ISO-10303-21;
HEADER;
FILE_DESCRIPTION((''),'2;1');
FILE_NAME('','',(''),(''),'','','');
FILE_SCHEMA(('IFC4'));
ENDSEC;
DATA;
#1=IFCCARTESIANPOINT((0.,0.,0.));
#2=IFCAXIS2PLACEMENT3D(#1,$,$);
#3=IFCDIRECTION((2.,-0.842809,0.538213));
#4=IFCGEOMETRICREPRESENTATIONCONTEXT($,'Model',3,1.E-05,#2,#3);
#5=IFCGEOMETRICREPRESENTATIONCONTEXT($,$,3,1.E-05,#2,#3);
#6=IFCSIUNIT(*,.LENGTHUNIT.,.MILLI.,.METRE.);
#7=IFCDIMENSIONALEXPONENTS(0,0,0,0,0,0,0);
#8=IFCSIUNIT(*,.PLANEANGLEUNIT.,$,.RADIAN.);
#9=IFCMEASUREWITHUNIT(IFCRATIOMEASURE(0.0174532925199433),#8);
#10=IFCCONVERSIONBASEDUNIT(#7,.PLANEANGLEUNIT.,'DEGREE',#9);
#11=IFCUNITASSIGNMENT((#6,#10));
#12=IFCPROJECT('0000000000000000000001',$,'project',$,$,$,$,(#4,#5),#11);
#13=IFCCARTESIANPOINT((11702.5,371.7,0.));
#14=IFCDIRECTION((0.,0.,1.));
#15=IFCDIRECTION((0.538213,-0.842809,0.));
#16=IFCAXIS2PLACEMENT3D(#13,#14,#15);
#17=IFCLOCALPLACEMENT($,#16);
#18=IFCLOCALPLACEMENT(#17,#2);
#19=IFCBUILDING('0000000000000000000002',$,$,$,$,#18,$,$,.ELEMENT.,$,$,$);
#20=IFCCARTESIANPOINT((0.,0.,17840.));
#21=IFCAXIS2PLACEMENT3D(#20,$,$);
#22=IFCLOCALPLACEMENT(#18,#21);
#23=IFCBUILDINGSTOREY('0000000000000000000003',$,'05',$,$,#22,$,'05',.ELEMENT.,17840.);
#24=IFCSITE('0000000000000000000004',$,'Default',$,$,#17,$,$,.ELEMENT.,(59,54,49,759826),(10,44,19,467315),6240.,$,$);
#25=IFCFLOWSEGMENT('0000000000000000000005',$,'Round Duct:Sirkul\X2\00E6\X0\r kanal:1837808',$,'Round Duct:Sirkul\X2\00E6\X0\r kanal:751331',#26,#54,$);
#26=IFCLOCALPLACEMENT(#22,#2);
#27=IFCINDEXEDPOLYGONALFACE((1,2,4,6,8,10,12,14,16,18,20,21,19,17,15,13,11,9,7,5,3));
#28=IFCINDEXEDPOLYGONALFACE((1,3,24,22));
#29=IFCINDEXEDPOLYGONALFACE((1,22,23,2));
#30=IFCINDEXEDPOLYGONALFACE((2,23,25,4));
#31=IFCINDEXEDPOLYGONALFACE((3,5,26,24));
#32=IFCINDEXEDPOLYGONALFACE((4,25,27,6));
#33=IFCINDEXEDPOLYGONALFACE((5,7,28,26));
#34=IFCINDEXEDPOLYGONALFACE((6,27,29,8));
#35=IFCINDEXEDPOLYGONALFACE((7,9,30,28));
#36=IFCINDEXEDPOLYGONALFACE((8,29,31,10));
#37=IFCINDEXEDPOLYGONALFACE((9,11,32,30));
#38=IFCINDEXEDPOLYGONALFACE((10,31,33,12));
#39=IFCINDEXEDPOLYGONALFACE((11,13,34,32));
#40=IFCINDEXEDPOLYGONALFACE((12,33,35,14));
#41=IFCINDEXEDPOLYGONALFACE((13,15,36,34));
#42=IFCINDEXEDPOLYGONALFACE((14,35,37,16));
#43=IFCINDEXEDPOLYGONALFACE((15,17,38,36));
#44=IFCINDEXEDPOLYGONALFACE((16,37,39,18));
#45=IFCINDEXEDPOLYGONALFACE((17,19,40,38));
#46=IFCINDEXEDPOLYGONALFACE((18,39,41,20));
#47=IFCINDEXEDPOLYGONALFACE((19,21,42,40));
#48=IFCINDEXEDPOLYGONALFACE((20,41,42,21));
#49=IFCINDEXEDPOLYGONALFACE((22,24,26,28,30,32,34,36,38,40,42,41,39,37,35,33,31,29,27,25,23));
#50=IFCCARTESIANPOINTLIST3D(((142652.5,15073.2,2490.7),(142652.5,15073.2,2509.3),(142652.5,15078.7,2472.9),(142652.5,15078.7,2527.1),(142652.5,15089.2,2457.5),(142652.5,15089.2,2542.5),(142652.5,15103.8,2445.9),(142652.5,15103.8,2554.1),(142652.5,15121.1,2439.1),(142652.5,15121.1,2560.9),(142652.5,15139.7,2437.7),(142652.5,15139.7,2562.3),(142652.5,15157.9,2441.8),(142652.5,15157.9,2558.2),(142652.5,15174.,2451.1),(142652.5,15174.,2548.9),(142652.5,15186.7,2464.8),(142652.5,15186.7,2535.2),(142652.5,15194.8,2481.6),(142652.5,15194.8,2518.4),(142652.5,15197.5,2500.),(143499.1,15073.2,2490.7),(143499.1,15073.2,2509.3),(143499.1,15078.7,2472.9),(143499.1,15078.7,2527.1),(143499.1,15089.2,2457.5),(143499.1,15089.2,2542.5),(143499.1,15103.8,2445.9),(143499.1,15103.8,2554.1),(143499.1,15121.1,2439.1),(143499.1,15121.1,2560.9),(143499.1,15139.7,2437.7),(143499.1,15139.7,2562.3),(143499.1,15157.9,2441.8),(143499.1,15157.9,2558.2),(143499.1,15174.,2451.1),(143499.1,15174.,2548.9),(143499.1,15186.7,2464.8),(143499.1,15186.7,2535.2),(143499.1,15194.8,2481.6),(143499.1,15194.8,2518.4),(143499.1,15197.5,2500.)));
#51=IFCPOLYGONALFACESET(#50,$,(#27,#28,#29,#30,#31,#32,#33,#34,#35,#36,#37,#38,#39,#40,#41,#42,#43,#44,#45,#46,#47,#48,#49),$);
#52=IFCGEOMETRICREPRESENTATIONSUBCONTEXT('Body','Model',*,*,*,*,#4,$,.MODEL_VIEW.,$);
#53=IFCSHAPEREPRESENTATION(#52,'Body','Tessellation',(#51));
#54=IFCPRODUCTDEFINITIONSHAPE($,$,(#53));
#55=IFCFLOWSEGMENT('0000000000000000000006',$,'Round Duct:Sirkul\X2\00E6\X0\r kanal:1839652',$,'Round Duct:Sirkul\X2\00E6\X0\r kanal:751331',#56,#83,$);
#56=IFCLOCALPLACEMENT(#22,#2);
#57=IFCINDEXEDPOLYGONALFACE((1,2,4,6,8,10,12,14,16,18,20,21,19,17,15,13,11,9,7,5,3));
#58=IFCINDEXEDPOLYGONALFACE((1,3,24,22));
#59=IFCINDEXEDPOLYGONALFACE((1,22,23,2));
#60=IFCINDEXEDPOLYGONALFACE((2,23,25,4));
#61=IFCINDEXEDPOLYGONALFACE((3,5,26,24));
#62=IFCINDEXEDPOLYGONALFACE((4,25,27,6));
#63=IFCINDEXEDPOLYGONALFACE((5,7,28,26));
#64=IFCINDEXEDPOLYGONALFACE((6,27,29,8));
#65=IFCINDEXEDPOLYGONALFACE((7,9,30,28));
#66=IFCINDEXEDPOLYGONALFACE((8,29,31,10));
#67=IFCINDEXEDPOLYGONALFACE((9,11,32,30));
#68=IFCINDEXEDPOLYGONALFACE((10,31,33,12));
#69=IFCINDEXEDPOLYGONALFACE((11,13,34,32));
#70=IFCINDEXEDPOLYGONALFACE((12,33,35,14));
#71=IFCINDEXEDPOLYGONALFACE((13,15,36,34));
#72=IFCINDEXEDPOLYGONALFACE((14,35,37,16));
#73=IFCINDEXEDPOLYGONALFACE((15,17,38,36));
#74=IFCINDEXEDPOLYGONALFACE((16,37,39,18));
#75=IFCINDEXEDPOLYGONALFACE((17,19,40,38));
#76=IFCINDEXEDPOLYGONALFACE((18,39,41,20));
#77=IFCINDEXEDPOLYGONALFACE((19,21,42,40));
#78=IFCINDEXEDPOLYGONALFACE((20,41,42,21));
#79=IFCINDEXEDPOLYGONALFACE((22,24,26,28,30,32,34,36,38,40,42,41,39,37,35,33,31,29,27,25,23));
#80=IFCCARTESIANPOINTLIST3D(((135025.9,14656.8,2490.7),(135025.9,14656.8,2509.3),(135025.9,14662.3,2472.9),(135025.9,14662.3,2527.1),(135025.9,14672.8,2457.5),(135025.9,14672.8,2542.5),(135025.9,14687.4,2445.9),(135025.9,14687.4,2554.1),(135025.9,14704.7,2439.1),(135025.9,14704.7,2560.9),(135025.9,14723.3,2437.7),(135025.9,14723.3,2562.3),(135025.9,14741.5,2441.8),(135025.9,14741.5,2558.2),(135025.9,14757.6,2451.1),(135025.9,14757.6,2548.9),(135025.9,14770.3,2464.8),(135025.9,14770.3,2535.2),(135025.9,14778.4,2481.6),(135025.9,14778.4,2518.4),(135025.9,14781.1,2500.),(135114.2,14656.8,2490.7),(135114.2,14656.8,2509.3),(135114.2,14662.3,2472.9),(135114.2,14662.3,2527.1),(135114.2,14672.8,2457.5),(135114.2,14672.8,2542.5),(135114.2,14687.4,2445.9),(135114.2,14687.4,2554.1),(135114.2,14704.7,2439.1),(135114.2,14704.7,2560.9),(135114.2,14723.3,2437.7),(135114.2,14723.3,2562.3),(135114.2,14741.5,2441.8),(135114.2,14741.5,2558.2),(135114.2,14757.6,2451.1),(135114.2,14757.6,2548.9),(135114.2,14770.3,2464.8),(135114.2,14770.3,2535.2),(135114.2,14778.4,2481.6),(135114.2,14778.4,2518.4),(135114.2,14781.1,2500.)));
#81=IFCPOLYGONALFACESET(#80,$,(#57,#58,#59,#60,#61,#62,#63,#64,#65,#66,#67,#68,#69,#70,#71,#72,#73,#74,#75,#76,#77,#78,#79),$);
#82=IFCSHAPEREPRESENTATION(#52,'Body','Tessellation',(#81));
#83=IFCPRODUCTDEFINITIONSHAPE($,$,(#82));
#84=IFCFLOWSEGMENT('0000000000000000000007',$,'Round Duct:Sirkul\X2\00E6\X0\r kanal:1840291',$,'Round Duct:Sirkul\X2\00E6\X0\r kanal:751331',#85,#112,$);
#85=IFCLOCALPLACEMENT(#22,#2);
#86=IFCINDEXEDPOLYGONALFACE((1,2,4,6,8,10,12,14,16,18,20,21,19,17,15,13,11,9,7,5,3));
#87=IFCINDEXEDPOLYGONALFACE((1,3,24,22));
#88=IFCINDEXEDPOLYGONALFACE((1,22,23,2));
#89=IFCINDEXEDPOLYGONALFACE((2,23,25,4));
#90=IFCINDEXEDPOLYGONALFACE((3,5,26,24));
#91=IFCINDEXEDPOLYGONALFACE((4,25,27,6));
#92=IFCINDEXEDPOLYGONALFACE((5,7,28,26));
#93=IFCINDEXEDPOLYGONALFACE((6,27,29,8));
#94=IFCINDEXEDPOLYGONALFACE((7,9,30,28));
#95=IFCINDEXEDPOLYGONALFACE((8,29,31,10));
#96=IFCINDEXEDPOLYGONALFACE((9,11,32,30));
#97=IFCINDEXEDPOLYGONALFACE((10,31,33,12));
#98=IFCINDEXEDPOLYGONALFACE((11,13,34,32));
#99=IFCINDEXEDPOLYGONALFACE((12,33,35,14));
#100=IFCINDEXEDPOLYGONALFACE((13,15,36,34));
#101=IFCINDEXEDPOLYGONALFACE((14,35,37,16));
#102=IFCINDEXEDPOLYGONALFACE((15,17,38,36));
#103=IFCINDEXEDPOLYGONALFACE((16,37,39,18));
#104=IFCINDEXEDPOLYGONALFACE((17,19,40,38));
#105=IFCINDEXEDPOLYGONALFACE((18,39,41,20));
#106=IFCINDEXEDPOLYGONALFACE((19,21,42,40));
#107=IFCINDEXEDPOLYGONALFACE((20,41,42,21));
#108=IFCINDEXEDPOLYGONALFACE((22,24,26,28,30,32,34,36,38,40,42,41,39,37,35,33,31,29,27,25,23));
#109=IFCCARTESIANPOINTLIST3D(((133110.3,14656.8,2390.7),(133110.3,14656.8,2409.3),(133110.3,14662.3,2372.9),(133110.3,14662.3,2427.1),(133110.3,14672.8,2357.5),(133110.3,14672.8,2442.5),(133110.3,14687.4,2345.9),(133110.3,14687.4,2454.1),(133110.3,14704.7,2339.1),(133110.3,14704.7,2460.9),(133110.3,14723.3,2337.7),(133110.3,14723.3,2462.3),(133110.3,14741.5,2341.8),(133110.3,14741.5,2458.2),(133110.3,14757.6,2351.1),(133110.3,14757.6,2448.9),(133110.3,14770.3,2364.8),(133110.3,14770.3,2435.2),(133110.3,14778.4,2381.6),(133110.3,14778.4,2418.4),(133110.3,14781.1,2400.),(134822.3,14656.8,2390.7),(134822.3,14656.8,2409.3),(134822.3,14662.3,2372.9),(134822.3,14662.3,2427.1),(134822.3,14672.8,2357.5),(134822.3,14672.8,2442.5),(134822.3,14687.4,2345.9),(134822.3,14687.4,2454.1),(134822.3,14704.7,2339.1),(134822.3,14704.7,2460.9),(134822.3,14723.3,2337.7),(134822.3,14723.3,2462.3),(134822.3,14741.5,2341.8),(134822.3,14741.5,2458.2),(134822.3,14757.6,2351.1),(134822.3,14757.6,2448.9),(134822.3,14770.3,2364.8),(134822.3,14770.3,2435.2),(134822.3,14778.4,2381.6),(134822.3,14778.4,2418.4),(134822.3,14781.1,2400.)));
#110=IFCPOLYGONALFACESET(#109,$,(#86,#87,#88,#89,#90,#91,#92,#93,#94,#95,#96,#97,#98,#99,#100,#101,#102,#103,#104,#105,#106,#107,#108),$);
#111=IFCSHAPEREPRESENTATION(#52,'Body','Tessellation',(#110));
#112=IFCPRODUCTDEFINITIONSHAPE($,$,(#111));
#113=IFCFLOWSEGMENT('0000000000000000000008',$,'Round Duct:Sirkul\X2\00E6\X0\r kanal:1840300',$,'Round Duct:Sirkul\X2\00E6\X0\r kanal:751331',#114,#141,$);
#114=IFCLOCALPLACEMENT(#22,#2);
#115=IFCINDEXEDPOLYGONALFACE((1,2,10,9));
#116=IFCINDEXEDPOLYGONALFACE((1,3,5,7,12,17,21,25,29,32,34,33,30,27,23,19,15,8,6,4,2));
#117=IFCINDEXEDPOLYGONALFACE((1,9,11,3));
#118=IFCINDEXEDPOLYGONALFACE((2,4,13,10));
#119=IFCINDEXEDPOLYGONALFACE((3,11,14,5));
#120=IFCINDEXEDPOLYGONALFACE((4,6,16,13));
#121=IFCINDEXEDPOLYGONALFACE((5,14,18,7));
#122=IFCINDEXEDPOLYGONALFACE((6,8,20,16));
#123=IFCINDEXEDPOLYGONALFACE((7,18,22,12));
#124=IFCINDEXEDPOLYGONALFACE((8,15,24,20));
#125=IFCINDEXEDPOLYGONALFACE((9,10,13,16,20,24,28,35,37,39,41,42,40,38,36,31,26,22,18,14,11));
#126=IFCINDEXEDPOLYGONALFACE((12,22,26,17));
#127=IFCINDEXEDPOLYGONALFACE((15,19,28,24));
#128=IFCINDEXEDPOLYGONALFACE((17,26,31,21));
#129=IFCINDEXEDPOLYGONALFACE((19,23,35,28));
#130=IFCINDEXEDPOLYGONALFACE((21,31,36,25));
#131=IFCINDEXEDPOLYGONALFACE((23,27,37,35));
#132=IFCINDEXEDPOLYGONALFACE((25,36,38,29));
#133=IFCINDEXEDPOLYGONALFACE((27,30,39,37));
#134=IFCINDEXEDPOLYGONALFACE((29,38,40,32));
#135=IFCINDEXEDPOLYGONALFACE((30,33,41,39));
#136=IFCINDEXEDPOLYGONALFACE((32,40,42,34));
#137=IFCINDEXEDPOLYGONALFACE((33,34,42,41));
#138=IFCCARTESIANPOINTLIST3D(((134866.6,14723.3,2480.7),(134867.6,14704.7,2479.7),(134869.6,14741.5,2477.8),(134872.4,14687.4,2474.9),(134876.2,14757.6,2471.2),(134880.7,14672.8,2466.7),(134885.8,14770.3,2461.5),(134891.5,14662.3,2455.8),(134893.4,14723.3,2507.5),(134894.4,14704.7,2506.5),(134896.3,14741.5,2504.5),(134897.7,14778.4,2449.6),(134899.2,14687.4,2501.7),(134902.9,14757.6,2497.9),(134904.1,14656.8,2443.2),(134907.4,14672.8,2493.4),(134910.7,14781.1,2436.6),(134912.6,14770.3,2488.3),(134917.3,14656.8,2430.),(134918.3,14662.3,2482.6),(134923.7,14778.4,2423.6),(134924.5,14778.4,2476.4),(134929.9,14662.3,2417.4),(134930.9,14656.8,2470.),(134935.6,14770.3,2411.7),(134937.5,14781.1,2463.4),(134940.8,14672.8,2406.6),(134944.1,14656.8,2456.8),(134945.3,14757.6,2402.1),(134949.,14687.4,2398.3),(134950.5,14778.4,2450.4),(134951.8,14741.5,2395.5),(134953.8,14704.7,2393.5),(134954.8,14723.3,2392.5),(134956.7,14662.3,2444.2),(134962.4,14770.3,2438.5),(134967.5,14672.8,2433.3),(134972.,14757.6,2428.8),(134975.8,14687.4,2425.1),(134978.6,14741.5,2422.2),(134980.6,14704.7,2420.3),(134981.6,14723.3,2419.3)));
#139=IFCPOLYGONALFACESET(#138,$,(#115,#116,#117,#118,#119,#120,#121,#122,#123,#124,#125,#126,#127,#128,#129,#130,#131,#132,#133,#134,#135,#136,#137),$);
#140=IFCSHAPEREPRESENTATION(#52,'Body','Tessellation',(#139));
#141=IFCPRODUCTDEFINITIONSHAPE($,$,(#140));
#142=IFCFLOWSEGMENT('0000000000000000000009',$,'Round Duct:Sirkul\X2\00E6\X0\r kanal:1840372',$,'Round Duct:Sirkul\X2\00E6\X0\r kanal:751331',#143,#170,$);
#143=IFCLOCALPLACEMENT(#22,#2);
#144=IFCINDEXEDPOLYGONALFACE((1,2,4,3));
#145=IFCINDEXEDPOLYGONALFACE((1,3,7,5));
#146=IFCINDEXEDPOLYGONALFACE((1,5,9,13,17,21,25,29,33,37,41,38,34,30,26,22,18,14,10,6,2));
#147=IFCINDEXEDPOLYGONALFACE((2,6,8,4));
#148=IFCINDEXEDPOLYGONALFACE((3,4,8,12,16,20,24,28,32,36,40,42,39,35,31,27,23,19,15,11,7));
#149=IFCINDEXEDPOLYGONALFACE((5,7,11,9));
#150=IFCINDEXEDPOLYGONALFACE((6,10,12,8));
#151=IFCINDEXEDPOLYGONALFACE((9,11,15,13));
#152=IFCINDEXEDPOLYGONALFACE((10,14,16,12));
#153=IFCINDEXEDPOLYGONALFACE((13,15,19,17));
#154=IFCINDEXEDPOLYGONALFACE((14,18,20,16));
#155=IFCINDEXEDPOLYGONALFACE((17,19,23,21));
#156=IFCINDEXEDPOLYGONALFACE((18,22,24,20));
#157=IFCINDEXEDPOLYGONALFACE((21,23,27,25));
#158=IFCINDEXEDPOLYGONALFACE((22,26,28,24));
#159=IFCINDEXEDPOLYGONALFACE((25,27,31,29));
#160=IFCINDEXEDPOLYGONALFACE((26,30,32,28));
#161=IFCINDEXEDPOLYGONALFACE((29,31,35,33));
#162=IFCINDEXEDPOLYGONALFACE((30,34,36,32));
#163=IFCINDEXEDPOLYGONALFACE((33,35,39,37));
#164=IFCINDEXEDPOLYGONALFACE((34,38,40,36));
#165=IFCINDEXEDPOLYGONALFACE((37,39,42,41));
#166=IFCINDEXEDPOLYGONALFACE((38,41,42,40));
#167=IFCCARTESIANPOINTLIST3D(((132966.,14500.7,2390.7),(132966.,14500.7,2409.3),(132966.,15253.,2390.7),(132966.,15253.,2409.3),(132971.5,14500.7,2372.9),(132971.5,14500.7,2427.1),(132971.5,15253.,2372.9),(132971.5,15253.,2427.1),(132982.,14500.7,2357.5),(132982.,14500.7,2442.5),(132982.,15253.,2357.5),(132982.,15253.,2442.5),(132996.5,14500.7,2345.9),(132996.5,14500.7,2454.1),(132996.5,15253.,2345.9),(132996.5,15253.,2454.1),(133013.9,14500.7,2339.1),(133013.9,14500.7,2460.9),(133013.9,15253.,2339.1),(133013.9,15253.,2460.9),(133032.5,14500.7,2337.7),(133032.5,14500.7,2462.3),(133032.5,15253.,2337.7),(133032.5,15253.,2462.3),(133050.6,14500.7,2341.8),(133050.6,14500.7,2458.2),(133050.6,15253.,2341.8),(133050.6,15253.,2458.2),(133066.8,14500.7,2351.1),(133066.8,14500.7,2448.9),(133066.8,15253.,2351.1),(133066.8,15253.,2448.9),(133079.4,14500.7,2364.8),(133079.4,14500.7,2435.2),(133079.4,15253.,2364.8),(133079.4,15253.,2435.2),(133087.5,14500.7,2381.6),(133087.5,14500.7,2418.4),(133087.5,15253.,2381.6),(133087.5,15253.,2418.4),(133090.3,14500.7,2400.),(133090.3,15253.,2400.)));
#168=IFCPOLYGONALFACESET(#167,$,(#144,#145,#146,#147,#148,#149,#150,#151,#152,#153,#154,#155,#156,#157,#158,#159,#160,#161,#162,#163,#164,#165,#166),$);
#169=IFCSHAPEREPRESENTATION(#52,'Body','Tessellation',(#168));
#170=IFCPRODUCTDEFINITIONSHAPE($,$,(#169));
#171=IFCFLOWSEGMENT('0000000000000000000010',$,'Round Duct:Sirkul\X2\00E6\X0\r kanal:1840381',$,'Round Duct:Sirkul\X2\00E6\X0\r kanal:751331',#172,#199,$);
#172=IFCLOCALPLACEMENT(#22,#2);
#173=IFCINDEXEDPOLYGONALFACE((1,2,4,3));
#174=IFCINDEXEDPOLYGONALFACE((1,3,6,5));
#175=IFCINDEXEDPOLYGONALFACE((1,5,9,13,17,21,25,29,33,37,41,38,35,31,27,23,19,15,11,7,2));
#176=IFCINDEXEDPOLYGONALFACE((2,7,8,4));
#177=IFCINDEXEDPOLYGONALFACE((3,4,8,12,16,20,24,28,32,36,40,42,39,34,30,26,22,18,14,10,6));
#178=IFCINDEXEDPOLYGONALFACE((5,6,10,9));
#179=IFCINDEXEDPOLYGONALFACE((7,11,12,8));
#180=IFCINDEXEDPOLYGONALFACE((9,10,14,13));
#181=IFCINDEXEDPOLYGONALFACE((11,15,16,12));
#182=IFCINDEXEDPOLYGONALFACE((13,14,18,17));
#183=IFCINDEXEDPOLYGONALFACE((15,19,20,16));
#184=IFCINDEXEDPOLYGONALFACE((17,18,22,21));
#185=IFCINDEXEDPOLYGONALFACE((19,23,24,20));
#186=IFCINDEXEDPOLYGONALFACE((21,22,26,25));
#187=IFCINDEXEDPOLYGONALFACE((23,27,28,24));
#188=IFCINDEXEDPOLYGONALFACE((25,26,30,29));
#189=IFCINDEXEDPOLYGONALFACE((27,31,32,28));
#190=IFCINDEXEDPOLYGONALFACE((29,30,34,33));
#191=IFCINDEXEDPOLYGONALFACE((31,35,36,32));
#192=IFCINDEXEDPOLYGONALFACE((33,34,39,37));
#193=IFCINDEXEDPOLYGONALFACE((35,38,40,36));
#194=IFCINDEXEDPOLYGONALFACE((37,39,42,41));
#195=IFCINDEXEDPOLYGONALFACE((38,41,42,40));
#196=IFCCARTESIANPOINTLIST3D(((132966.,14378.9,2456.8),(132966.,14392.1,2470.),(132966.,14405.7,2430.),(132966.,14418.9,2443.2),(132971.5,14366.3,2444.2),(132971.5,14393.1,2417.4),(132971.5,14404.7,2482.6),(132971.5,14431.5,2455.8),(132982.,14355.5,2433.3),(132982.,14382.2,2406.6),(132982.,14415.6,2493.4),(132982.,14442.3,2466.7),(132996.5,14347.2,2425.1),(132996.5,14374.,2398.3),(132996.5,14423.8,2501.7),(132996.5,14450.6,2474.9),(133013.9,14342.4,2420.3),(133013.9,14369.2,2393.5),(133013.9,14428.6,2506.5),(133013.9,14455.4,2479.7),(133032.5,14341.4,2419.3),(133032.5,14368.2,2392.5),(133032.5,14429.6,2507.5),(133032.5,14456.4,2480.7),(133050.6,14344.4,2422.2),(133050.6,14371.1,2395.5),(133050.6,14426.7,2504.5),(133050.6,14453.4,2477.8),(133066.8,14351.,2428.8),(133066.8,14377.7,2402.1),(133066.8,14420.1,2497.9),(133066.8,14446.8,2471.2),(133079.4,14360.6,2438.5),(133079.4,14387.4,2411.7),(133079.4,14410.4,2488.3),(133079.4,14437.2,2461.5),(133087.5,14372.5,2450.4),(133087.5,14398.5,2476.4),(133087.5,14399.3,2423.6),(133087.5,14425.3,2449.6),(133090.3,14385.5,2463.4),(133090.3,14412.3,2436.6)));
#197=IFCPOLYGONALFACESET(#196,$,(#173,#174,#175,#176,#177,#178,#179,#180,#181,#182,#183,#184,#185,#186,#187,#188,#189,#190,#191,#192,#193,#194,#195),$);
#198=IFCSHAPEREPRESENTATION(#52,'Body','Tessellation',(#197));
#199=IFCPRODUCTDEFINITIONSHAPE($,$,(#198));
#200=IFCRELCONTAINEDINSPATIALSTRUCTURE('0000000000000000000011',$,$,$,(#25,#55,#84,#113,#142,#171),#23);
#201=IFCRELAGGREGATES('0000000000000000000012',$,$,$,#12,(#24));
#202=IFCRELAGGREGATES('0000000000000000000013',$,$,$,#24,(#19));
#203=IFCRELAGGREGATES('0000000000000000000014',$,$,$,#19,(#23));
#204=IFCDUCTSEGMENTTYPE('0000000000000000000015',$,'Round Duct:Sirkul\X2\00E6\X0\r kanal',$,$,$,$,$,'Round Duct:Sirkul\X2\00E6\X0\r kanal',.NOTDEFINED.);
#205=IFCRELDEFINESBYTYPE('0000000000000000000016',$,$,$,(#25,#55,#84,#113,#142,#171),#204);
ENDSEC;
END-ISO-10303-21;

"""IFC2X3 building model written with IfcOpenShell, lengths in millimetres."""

from ifc_helpers import new_model, entity, si_unit, converted_unit, direction, frame, frame_2d, origin, origin_2d_with_axis, place, context, subcontext, project, spatial, circle, extrude, type_object, element, save


model = new_model("IFC2X3")

# Units and contexts
model_context = context("Model", 3, precision=1e-05, world=origin(), true_north=direction((2.0, -0.842809, 0.538213)))
context_of_model = context(None, 3, precision=1e-05, world=origin(), true_north=direction((2.0, -0.842809, 0.538213)))
body_context = subcontext(model_context, "Body", "Model", "MODEL_VIEW")
ifc_project = project(units=[si_unit("LENGTHUNIT", "METRE", prefix="MILLI"), converted_unit("PLANEANGLEUNIT", "DEGREE", entity("IfcRatioMeasure", 0.0174532925199433), si_unit("PLANEANGLEUNIT", "RADIAN"), dimensions=[0, 0, 0, 0, 0, 0, 0])], contexts=[model_context, context_of_model])

# Site, building, storey
site_placement = place(None, frame((11702.5, 371.7, 0.0), z_axis=(0.0, 0.0, 1.0), x_axis=(0.538213, -0.842809, 0.0)))
site = spatial("IfcSite", under=ifc_project, at=site_placement, Name="Default", CompositionType="ELEMENT", RefLatitude=(59, 54, 49, 759826), RefLongitude=(10, 44, 19, 467315), RefElevation=6240.0)
building_placement = place(site_placement, origin())
building = spatial("IfcBuilding", under=site, at=building_placement, CompositionType="ELEMENT")
storey_placement = place(building_placement, frame((0.0, 0.0, 17840.0)))
storey = spatial("IfcBuildingStorey", under=building, at=storey_placement, Name="05", LongName="05", CompositionType="ELEMENT", Elevation=17840.0)

# Flow segments
duct_segment_type_1 = type_object("IfcDuctSegmentType", Name="Round Duct:Sirkulær kanal", ElementType="Round Duct:Sirkulær kanal", PredefinedType="NOTDEFINED")
flow_segment_1_placement = place(storey_placement, origin())
element("IfcFlowSegment", 1, at=flow_segment_1_placement, inside=storey, type_object=duct_segment_type_1, Name="Round Duct:Sirkulær kanal:1837808", ObjectType="Round Duct:Sirkulær kanal:751331", context=body_context, shape_type="SweptSolid", body=[
    extrude(circle(Radius=62.5, at=frame_2d((0.0, 0.0), x_axis=(1.0, 0.0))), frame((142652.5, 15135.0, 2500.0), z_axis=(1.0, 0.0, 0.0), x_axis=(0.0, 1.0, 0.0)), (0.0, 0.0, 1.0), 846.5),
])
flow_segment_2_placement = place(storey_placement, origin())
element("IfcFlowSegment", 2, at=flow_segment_2_placement, inside=storey, type_object=duct_segment_type_1, Name="Round Duct:Sirkulær kanal:1839652", ObjectType="Round Duct:Sirkulær kanal:751331", context=body_context, shape_type="SweptSolid", body=[
    extrude(circle(Radius=62.5, at=frame_2d((0.0, 0.0), x_axis=(1.0, 0.0))), frame((135025.9, 14718.6, 2500.0), z_axis=(1.0, 0.0, 0.0), x_axis=(0.0, 1.0, 0.0)), (0.0, 0.0, 1.0), 88.3),
])
flow_segment_3_placement = place(storey_placement, origin())
element("IfcFlowSegment", 3, at=flow_segment_3_placement, inside=storey, type_object=duct_segment_type_1, Name="Round Duct:Sirkulær kanal:1840291", ObjectType="Round Duct:Sirkulær kanal:751331", context=body_context, shape_type="SweptSolid", body=[
    extrude(circle(Radius=62.5, at=frame_2d((0.0, 0.0), x_axis=(1.0, 0.0))), frame((133110.3, 14718.6, 2400.0), z_axis=(1.0, 0.0, 0.0), x_axis=(0.0, 1.0, 0.0)), (0.0, 0.0, 1.0), 1712.0),
])
flow_segment_4_placement = place(storey_placement, origin())
element("IfcFlowSegment", 4, at=flow_segment_4_placement, inside=storey, type_object=duct_segment_type_1, Name="Round Duct:Sirkulær kanal:1840300", ObjectType="Round Duct:Sirkulær kanal:751331", context=body_context, shape_type="SweptSolid", body=[
    extrude(circle(Radius=62.5, at=frame_2d((0.0, 0.0), x_axis=(1.0, 0.0))), frame((134910.7, 14718.6, 2436.6), z_axis=(0.707107, 0.0, 0.707107), x_axis=(0.0, 1.0, 0.0)), (0.0, 0.0, 1.0), 37.9),
])
flow_segment_5_placement = place(storey_placement, origin())
element("IfcFlowSegment", 5, at=flow_segment_5_placement, inside=storey, type_object=duct_segment_type_1, Name="Round Duct:Sirkulær kanal:1840372", ObjectType="Round Duct:Sirkulær kanal:751331", context=body_context, shape_type="SweptSolid", body=[
    extrude(circle(Radius=62.5, at=origin_2d_with_axis()), frame((133027.8, 14500.7, 2400.0), z_axis=(0.0, 1.0, 0.0), x_axis=(1.0, 0.0, 0.0)), (0.0, 0.0, 1.0), 752.4),
])
flow_segment_6_placement = place(storey_placement, origin())
element("IfcFlowSegment", 6, at=flow_segment_6_placement, inside=storey, type_object=duct_segment_type_1, Name="Round Duct:Sirkulær kanal:1840381", ObjectType="Round Duct:Sirkulær kanal:751331", context=body_context, shape_type="SweptSolid", body=[
    extrude(circle(Radius=62.5, at=frame_2d((0.0, 0.0), x_axis=(1.0, 0.0))), frame((133027.8, 14412.3, 2436.6), z_axis=(0.0, -0.707107, 0.707107), x_axis=(1.0, 0.0, 0.0)), (0.0, 0.0, 1.0), 37.9),
])

save(model, "model.ifc")
